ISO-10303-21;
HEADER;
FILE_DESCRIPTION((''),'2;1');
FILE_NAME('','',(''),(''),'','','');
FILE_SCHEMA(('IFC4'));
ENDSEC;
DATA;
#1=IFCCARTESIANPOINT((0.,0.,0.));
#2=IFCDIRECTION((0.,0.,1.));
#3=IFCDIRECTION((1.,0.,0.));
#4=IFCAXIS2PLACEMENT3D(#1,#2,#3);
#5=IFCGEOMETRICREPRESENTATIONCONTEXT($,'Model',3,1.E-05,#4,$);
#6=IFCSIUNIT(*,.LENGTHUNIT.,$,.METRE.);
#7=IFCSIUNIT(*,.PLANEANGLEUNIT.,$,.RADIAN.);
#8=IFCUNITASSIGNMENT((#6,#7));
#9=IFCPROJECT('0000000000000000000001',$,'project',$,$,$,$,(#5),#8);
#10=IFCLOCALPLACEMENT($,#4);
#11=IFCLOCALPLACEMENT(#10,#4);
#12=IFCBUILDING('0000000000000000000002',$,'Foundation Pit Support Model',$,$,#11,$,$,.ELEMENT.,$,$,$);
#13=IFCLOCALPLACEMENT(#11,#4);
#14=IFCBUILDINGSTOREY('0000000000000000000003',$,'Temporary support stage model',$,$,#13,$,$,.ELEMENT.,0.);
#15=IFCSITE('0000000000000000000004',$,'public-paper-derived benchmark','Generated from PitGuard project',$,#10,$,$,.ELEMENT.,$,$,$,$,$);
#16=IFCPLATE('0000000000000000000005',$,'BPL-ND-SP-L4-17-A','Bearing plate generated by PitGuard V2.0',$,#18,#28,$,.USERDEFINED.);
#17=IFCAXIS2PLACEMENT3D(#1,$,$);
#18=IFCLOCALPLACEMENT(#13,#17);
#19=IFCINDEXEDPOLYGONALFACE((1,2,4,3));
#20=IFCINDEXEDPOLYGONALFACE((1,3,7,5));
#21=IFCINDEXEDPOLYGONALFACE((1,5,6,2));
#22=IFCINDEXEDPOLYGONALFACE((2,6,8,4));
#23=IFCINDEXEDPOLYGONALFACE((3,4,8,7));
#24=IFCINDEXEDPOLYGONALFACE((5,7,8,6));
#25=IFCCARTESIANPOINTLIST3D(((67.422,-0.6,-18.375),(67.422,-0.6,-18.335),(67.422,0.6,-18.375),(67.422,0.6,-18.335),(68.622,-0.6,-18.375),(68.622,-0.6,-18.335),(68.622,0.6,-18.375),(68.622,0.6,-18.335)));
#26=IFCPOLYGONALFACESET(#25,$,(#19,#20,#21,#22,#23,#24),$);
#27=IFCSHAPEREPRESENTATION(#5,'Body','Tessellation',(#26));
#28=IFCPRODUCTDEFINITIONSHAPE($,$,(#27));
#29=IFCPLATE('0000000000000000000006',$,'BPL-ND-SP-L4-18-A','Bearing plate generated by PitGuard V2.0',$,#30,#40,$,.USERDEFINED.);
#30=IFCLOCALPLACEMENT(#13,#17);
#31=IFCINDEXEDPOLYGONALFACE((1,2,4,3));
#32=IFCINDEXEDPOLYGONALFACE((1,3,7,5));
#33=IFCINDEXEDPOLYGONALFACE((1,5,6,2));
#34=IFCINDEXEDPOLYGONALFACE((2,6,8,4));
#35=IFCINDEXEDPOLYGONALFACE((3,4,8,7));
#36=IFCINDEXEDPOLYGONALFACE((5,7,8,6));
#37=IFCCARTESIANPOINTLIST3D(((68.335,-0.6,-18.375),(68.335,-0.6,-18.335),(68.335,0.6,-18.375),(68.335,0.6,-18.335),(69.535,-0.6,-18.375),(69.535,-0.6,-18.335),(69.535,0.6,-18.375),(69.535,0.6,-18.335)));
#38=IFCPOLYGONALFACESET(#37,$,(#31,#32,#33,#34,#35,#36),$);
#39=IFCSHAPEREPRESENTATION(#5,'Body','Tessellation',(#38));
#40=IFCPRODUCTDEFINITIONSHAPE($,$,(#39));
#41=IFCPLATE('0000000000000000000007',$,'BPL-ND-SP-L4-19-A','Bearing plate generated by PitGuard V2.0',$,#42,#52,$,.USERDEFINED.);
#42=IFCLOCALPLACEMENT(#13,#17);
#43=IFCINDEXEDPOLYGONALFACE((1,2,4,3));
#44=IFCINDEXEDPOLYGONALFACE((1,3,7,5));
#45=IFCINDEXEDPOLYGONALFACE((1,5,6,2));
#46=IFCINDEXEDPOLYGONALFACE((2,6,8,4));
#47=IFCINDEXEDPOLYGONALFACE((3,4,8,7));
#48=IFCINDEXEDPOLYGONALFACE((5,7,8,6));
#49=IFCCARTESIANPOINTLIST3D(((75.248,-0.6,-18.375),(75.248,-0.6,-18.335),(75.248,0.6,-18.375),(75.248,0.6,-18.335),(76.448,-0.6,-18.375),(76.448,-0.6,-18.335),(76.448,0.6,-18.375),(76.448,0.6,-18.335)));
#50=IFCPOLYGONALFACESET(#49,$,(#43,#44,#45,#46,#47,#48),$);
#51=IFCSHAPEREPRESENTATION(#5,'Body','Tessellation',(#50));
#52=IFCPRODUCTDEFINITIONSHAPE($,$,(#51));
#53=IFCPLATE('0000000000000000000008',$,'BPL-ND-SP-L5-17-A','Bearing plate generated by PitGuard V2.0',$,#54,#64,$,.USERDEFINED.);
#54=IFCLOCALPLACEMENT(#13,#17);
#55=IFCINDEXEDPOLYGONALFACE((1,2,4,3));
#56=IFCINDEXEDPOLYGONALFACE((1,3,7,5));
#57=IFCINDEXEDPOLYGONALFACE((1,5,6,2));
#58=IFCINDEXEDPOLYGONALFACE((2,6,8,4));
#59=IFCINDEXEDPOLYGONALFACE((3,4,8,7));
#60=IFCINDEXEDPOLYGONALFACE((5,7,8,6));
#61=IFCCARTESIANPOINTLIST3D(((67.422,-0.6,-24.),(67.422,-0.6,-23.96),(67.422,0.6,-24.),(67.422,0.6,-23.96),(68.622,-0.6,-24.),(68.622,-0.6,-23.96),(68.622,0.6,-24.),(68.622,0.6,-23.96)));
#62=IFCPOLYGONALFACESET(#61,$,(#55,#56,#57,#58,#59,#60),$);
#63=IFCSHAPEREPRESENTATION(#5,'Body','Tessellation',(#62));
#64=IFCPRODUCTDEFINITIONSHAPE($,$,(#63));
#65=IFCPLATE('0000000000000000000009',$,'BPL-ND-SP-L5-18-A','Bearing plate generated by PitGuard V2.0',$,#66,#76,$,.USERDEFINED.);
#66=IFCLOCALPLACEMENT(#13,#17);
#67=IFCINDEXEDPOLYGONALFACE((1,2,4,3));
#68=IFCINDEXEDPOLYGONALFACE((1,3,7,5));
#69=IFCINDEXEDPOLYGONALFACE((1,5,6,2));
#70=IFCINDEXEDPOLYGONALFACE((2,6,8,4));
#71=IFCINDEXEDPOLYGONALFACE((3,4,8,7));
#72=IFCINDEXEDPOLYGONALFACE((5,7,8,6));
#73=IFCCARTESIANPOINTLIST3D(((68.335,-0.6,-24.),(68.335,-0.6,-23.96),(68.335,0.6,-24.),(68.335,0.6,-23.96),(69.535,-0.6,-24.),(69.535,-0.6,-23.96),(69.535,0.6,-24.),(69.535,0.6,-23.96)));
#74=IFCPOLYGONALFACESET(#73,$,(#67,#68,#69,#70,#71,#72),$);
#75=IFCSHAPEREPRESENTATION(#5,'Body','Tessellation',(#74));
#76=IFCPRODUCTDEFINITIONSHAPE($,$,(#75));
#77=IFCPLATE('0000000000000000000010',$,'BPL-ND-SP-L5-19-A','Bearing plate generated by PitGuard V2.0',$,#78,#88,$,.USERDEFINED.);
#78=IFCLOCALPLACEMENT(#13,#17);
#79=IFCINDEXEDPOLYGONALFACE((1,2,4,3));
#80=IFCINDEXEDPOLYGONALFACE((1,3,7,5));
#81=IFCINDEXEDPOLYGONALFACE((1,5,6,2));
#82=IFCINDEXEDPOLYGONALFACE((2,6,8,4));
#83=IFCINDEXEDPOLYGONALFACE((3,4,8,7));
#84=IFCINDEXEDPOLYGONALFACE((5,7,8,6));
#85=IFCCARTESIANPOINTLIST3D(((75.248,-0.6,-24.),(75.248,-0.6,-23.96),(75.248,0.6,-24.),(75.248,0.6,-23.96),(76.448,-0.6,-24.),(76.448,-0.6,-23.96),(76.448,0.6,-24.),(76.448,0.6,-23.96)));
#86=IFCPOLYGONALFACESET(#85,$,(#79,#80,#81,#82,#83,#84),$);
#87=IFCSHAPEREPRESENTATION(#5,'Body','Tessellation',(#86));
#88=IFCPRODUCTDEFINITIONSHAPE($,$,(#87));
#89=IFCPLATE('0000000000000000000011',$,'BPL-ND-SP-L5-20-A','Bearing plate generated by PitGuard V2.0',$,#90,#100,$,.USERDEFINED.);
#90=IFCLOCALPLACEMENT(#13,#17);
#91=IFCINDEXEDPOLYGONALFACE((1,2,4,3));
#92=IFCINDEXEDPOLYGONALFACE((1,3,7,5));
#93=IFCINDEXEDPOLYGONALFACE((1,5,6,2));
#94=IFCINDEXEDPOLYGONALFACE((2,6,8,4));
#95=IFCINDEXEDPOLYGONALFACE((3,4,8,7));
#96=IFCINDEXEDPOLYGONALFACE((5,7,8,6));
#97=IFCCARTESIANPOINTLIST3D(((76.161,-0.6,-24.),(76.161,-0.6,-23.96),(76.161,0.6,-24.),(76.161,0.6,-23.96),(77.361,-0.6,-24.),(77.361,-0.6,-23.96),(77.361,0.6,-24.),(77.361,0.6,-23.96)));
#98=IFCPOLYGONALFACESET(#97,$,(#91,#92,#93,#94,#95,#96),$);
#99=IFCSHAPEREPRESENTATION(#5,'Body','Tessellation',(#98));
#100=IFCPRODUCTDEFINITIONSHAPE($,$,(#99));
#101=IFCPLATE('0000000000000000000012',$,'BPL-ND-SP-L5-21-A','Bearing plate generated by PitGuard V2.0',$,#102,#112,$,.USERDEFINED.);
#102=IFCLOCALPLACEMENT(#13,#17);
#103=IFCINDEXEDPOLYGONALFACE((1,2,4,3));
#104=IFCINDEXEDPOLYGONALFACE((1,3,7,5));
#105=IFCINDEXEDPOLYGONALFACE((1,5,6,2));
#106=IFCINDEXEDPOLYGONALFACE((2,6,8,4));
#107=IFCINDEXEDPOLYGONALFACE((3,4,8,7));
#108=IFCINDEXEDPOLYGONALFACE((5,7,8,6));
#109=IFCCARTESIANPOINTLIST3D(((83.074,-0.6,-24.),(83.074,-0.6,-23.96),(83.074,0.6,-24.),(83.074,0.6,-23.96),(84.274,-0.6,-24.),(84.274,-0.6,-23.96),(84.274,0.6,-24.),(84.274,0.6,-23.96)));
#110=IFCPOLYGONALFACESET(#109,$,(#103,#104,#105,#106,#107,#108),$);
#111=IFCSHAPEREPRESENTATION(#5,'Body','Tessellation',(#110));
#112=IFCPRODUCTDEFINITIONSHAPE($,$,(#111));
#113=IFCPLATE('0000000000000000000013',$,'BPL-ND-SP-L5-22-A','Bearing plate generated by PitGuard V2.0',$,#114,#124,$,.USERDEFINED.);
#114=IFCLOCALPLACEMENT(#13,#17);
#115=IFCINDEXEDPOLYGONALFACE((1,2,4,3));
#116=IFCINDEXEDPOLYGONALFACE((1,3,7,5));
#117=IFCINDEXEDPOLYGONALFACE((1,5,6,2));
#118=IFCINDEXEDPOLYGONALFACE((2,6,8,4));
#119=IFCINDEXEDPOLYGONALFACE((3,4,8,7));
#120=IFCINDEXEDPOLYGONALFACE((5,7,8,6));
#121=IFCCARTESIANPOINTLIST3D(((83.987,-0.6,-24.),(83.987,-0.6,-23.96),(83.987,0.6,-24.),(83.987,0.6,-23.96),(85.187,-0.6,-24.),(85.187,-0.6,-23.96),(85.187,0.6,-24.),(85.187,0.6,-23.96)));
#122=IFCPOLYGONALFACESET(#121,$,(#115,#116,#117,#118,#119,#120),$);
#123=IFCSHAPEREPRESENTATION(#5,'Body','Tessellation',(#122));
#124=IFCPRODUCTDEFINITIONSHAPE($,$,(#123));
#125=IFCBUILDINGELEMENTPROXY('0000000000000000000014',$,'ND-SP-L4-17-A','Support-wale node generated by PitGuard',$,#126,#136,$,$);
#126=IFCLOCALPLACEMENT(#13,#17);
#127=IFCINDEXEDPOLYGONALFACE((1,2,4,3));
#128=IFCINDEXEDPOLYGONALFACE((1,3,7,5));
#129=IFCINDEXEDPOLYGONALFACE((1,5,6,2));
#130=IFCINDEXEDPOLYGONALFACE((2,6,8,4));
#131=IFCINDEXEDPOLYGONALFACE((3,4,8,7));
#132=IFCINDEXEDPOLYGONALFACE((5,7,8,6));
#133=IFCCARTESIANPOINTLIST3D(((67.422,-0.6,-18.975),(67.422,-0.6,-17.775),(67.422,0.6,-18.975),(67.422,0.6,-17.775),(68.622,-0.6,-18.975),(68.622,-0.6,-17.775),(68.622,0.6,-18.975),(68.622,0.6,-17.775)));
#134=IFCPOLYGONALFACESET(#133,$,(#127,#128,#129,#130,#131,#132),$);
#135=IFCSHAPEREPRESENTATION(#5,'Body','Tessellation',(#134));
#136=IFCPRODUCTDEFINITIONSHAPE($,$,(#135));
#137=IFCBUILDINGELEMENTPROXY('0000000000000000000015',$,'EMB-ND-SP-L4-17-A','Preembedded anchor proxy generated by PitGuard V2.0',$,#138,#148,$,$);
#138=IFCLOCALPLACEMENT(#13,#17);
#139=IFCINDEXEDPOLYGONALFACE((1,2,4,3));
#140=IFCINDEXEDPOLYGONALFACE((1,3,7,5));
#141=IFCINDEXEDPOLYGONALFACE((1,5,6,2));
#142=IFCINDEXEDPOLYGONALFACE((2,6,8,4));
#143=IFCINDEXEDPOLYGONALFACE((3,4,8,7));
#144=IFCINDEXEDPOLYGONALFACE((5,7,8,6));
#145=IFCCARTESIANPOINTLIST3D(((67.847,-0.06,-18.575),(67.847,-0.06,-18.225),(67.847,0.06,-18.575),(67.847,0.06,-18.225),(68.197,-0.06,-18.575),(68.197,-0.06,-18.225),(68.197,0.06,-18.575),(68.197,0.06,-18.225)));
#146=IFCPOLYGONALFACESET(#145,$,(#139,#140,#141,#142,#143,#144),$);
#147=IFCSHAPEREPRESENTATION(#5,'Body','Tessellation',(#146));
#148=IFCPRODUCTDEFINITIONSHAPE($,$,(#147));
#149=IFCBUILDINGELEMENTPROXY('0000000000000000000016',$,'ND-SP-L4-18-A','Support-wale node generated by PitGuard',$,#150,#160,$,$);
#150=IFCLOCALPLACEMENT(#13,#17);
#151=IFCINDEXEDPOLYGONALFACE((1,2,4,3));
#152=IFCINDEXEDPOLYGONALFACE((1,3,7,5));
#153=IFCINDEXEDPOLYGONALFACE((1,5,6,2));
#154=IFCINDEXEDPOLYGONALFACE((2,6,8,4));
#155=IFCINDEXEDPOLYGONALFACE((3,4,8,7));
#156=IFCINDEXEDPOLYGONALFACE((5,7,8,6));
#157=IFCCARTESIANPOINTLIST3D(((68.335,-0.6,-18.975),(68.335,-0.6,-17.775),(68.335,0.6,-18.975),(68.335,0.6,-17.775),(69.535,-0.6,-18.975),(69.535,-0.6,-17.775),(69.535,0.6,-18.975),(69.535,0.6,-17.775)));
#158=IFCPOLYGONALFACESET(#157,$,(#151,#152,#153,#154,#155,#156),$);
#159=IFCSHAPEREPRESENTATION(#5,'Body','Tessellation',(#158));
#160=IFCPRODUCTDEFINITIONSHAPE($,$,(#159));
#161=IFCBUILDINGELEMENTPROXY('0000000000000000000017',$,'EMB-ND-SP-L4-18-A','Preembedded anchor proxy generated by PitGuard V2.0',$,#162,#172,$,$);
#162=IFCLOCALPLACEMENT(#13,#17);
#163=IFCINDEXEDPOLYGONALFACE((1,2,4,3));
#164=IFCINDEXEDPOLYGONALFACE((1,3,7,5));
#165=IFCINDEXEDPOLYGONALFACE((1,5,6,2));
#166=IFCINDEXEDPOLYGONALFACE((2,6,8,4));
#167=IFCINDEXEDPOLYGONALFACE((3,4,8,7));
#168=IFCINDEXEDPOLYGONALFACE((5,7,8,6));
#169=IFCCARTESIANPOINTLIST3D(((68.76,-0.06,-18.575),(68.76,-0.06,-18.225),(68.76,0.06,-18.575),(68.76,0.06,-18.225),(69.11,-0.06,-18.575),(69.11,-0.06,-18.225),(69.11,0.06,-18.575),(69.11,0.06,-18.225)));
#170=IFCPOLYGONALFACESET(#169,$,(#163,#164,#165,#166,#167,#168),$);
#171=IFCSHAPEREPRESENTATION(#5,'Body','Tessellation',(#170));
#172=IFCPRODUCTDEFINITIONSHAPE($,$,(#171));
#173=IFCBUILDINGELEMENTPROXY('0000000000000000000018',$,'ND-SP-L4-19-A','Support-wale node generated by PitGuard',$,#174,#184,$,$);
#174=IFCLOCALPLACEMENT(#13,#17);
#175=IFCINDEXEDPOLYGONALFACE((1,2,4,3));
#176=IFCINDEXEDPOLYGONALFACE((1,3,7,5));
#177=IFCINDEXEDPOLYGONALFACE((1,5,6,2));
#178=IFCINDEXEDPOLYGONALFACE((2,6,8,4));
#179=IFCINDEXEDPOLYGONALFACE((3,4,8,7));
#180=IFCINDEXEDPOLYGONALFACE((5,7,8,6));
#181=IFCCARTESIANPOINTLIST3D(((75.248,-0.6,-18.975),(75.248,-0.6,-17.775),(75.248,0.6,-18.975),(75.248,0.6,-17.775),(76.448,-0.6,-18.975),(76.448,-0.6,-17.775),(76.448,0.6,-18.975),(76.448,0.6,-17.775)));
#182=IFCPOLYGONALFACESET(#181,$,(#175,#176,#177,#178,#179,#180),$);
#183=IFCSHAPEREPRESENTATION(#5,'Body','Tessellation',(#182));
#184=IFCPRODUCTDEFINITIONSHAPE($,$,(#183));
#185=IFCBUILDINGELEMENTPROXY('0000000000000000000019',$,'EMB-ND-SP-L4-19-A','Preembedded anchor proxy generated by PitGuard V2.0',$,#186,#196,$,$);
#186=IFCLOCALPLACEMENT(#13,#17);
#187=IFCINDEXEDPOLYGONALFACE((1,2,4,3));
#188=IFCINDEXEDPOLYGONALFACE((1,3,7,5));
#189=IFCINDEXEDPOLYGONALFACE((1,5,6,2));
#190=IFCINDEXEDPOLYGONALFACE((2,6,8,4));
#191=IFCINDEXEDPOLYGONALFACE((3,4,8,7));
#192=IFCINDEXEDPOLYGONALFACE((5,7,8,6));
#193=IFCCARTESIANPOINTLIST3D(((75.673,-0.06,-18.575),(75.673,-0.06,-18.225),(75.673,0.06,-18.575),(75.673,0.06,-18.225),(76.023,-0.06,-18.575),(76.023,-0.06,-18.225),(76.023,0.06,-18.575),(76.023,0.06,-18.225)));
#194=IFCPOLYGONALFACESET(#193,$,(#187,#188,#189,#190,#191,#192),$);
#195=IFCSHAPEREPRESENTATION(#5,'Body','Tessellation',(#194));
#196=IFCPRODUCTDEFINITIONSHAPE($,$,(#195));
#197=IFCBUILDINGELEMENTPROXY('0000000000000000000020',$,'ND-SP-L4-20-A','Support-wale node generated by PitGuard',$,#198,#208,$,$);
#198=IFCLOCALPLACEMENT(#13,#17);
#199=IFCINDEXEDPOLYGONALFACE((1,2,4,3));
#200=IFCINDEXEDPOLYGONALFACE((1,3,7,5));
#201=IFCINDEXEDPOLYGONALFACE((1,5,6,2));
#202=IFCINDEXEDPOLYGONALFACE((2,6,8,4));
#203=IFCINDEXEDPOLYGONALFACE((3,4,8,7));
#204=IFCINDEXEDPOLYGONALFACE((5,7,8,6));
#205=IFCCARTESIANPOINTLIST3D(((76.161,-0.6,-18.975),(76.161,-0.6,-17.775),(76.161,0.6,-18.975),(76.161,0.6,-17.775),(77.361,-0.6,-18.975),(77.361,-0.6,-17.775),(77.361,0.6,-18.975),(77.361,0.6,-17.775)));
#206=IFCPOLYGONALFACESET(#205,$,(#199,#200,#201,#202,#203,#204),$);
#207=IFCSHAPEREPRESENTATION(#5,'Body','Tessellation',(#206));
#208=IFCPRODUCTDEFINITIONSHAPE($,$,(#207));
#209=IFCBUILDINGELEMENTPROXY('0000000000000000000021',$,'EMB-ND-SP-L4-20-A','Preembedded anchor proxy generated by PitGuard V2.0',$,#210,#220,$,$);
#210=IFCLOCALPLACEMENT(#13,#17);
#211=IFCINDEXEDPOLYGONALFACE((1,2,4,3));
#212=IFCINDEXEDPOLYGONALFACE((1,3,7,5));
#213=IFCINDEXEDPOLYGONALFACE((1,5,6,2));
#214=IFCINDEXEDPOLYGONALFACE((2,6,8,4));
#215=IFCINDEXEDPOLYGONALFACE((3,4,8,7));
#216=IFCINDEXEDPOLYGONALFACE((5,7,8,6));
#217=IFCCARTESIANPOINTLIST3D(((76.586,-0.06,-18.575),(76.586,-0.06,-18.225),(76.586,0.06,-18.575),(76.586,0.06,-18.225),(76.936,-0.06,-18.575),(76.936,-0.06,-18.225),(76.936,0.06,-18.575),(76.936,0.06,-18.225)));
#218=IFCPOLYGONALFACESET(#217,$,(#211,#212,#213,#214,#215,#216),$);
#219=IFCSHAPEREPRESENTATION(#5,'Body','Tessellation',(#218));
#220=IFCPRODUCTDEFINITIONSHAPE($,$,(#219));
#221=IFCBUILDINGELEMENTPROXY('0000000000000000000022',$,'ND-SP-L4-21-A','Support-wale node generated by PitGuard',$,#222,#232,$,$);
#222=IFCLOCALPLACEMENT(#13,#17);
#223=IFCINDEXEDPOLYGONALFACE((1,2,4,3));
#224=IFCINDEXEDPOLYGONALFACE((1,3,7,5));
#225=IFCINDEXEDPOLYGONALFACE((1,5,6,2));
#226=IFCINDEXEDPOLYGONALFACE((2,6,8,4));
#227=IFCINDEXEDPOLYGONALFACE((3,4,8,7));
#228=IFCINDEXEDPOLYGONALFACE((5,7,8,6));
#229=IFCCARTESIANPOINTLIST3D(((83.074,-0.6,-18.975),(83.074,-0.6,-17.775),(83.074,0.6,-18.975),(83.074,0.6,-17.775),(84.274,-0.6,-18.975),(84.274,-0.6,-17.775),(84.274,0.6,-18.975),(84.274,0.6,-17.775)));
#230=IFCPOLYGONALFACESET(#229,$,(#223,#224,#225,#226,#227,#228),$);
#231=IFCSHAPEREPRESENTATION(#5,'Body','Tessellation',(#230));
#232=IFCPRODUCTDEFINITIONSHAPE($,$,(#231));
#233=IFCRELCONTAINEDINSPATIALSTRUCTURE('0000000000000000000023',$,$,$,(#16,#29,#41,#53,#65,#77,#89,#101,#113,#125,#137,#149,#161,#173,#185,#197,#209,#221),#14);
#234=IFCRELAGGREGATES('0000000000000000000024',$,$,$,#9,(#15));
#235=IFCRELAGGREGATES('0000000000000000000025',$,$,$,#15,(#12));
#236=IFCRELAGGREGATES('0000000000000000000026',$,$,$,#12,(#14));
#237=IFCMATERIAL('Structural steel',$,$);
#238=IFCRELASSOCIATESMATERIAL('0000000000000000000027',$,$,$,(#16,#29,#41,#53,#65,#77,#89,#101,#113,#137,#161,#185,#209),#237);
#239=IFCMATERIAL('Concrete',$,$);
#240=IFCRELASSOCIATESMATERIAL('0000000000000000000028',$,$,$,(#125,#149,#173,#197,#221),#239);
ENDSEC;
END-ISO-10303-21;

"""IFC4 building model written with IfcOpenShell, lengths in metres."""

from ifc_helpers import new_model, si_unit, frame, origin_with_axes, origin_2d, place, context, project, spatial, rectangle, extrude, material, element, save


model = new_model("IFC4")

# Units and contexts
model_context = context("Model", 3, precision=1e-05, world=origin_with_axes())
ifc_project = project(units=[si_unit("LENGTHUNIT", "METRE"), si_unit("PLANEANGLEUNIT", "RADIAN")], contexts=[model_context])

# Site, building, storey
site_placement = place(None, origin_with_axes())
site = spatial("IfcSite", under=ifc_project, at=site_placement, Name="public-paper-derived benchmark", Description="Generated from PitGuard project", CompositionType="ELEMENT")
building_placement = place(site_placement, origin_with_axes())
building = spatial("IfcBuilding", under=site, at=building_placement, Name="Foundation Pit Support Model", CompositionType="ELEMENT")
storey_placement = place(building_placement, origin_with_axes())
storey = spatial("IfcBuildingStorey", under=building, at=storey_placement, Name="Temporary support stage model", CompositionType="ELEMENT", Elevation=0.0)

# Plates
ifc_material_1 = material(Name="Structural steel")
for number, where, z_axis, x_axis, name in (
    (1, (68.022, 0.0, -18.375), (0.0, 0.0, 1.0), (1.0, 0.0, 0.0), "BPL-ND-SP-L4-17-A"),
    (2, (68.935, 0.0, -18.375), (0.0, 0.0, 1.0), (1.0, 0.0, 0.0), "BPL-ND-SP-L4-18-A"),
    (3, (75.848, 0.0, -18.375), (0.0, 0.0, 1.0), (1.0, 0.0, 0.0), "BPL-ND-SP-L4-19-A"),
    (4, (68.022, 0.0, -24.0), (0.0, 0.0, 1.0), (1.0, 0.0, 0.0), "BPL-ND-SP-L5-17-A"),
    (5, (68.935, 0.0, -24.0), (0.0, 0.0, 1.0), (1.0, 0.0, 0.0), "BPL-ND-SP-L5-18-A"),
    (6, (75.848, 0.0, -24.0), (0.0, 0.0, 1.0), (1.0, 0.0, 0.0), "BPL-ND-SP-L5-19-A"),
    (7, (76.761, 0.0, -24.0), (0.0, 0.0, 1.0), (1.0, 0.0, 0.0), "BPL-ND-SP-L5-20-A"),
    (8, (83.674, 0.0, -24.0), (0.0, 0.0, 1.0), (1.0, 0.0, 0.0), "BPL-ND-SP-L5-21-A"),
    (9, (84.587, 0.0, -24.0), (0.0, 0.0, 1.0), (1.0, 0.0, 0.0), "BPL-ND-SP-L5-22-A"),
):
    element("IfcPlate", number, at=place(storey_placement, frame(where, z_axis=z_axis, x_axis=x_axis)), inside=storey, material=ifc_material_1, Name=name, Description="Bearing plate generated by PitGuard V2.0", PredefinedType="USERDEFINED", context=model_context, shape_type="SweptSolid", body=[
        extrude(rectangle(XDim=1.2, YDim=1.2, at=origin_2d()), origin_with_axes(), (0.0, 0.0, 1.0), 0.04),
    ])

# Building element proxies
ifc_material_2 = material(Name="Concrete")
proxy_1_placement = place(storey_placement, frame((68.022, 0.0, -18.975), z_axis=(0.0, 0.0, 1.0), x_axis=(1.0, 0.0, 0.0)))
element("IfcBuildingElementProxy", 10, at=proxy_1_placement, inside=storey, material=ifc_material_2, Name="ND-SP-L4-17-A", Description="Support-wale node generated by PitGuard", context=model_context, shape_type="SweptSolid", body=[
    extrude(rectangle(XDim=1.2, YDim=1.2, at=origin_2d()), origin_with_axes(), (0.0, 0.0, 1.0), 1.2),
])
proxy_2_placement = place(storey_placement, frame((68.022, 0.0, -18.575), z_axis=(0.0, 0.0, 1.0), x_axis=(1.0, 0.0, 0.0)))
element("IfcBuildingElementProxy", 11, at=proxy_2_placement, inside=storey, material=ifc_material_1, Name="EMB-ND-SP-L4-17-A", Description="Preembedded anchor proxy generated by PitGuard V2.0", context=model_context, shape_type="SweptSolid", body=[
    extrude(rectangle(XDim=0.35, YDim=0.12, at=origin_2d()), origin_with_axes(), (0.0, 0.0, 1.0), 0.35),
])
proxy_3_placement = place(storey_placement, frame((68.935, 0.0, -18.975), z_axis=(0.0, 0.0, 1.0), x_axis=(1.0, 0.0, 0.0)))
element("IfcBuildingElementProxy", 12, at=proxy_3_placement, inside=storey, material=ifc_material_2, Name="ND-SP-L4-18-A", Description="Support-wale node generated by PitGuard", context=model_context, shape_type="SweptSolid", body=[
    extrude(rectangle(XDim=1.2, YDim=1.2, at=origin_2d()), origin_with_axes(), (0.0, 0.0, 1.0), 1.2),
])
proxy_4_placement = place(storey_placement, frame((68.935, 0.0, -18.575), z_axis=(0.0, 0.0, 1.0), x_axis=(1.0, 0.0, 0.0)))
element("IfcBuildingElementProxy", 13, at=proxy_4_placement, inside=storey, material=ifc_material_1, Name="EMB-ND-SP-L4-18-A", Description="Preembedded anchor proxy generated by PitGuard V2.0", context=model_context, shape_type="SweptSolid", body=[
    extrude(rectangle(XDim=0.35, YDim=0.12, at=origin_2d()), origin_with_axes(), (0.0, 0.0, 1.0), 0.35),
])
proxy_5_placement = place(storey_placement, frame((75.848, 0.0, -18.975), z_axis=(0.0, 0.0, 1.0), x_axis=(1.0, 0.0, 0.0)))
element("IfcBuildingElementProxy", 14, at=proxy_5_placement, inside=storey, material=ifc_material_2, Name="ND-SP-L4-19-A", Description="Support-wale node generated by PitGuard", context=model_context, shape_type="SweptSolid", body=[
    extrude(rectangle(XDim=1.2, YDim=1.2, at=origin_2d()), origin_with_axes(), (0.0, 0.0, 1.0), 1.2),
])
proxy_6_placement = place(storey_placement, frame((75.848, 0.0, -18.575), z_axis=(0.0, 0.0, 1.0), x_axis=(1.0, 0.0, 0.0)))
element("IfcBuildingElementProxy", 15, at=proxy_6_placement, inside=storey, material=ifc_material_1, Name="EMB-ND-SP-L4-19-A", Description="Preembedded anchor proxy generated by PitGuard V2.0", context=model_context, shape_type="SweptSolid", body=[
    extrude(rectangle(XDim=0.35, YDim=0.12, at=origin_2d()), origin_with_axes(), (0.0, 0.0, 1.0), 0.35),
])
proxy_7_placement = place(storey_placement, frame((76.761, 0.0, -18.975), z_axis=(0.0, 0.0, 1.0), x_axis=(1.0, 0.0, 0.0)))
element("IfcBuildingElementProxy", 16, at=proxy_7_placement, inside=storey, material=ifc_material_2, Name="ND-SP-L4-20-A", Description="Support-wale node generated by PitGuard", context=model_context, shape_type="SweptSolid", body=[
    extrude(rectangle(XDim=1.2, YDim=1.2, at=origin_2d()), origin_with_axes(), (0.0, 0.0, 1.0), 1.2),
])
proxy_8_placement = place(storey_placement, frame((76.761, 0.0, -18.575), z_axis=(0.0, 0.0, 1.0), x_axis=(1.0, 0.0, 0.0)))
element("IfcBuildingElementProxy", 17, at=proxy_8_placement, inside=storey, material=ifc_material_1, Name="EMB-ND-SP-L4-20-A", Description="Preembedded anchor proxy generated by PitGuard V2.0", context=model_context, shape_type="SweptSolid", body=[
    extrude(rectangle(XDim=0.35, YDim=0.12, at=origin_2d()), origin_with_axes(), (0.0, 0.0, 1.0), 0.35),
])
proxy_9_placement = place(storey_placement, frame((83.674, 0.0, -18.975), z_axis=(0.0, 0.0, 1.0), x_axis=(1.0, 0.0, 0.0)))
element("IfcBuildingElementProxy", 18, at=proxy_9_placement, inside=storey, material=ifc_material_2, Name="ND-SP-L4-21-A", Description="Support-wale node generated by PitGuard", context=model_context, shape_type="SweptSolid", body=[
    extrude(rectangle(XDim=1.2, YDim=1.2, at=origin_2d()), origin_with_axes(), (0.0, 0.0, 1.0), 1.2),
])

save(model, "model.ifc")
